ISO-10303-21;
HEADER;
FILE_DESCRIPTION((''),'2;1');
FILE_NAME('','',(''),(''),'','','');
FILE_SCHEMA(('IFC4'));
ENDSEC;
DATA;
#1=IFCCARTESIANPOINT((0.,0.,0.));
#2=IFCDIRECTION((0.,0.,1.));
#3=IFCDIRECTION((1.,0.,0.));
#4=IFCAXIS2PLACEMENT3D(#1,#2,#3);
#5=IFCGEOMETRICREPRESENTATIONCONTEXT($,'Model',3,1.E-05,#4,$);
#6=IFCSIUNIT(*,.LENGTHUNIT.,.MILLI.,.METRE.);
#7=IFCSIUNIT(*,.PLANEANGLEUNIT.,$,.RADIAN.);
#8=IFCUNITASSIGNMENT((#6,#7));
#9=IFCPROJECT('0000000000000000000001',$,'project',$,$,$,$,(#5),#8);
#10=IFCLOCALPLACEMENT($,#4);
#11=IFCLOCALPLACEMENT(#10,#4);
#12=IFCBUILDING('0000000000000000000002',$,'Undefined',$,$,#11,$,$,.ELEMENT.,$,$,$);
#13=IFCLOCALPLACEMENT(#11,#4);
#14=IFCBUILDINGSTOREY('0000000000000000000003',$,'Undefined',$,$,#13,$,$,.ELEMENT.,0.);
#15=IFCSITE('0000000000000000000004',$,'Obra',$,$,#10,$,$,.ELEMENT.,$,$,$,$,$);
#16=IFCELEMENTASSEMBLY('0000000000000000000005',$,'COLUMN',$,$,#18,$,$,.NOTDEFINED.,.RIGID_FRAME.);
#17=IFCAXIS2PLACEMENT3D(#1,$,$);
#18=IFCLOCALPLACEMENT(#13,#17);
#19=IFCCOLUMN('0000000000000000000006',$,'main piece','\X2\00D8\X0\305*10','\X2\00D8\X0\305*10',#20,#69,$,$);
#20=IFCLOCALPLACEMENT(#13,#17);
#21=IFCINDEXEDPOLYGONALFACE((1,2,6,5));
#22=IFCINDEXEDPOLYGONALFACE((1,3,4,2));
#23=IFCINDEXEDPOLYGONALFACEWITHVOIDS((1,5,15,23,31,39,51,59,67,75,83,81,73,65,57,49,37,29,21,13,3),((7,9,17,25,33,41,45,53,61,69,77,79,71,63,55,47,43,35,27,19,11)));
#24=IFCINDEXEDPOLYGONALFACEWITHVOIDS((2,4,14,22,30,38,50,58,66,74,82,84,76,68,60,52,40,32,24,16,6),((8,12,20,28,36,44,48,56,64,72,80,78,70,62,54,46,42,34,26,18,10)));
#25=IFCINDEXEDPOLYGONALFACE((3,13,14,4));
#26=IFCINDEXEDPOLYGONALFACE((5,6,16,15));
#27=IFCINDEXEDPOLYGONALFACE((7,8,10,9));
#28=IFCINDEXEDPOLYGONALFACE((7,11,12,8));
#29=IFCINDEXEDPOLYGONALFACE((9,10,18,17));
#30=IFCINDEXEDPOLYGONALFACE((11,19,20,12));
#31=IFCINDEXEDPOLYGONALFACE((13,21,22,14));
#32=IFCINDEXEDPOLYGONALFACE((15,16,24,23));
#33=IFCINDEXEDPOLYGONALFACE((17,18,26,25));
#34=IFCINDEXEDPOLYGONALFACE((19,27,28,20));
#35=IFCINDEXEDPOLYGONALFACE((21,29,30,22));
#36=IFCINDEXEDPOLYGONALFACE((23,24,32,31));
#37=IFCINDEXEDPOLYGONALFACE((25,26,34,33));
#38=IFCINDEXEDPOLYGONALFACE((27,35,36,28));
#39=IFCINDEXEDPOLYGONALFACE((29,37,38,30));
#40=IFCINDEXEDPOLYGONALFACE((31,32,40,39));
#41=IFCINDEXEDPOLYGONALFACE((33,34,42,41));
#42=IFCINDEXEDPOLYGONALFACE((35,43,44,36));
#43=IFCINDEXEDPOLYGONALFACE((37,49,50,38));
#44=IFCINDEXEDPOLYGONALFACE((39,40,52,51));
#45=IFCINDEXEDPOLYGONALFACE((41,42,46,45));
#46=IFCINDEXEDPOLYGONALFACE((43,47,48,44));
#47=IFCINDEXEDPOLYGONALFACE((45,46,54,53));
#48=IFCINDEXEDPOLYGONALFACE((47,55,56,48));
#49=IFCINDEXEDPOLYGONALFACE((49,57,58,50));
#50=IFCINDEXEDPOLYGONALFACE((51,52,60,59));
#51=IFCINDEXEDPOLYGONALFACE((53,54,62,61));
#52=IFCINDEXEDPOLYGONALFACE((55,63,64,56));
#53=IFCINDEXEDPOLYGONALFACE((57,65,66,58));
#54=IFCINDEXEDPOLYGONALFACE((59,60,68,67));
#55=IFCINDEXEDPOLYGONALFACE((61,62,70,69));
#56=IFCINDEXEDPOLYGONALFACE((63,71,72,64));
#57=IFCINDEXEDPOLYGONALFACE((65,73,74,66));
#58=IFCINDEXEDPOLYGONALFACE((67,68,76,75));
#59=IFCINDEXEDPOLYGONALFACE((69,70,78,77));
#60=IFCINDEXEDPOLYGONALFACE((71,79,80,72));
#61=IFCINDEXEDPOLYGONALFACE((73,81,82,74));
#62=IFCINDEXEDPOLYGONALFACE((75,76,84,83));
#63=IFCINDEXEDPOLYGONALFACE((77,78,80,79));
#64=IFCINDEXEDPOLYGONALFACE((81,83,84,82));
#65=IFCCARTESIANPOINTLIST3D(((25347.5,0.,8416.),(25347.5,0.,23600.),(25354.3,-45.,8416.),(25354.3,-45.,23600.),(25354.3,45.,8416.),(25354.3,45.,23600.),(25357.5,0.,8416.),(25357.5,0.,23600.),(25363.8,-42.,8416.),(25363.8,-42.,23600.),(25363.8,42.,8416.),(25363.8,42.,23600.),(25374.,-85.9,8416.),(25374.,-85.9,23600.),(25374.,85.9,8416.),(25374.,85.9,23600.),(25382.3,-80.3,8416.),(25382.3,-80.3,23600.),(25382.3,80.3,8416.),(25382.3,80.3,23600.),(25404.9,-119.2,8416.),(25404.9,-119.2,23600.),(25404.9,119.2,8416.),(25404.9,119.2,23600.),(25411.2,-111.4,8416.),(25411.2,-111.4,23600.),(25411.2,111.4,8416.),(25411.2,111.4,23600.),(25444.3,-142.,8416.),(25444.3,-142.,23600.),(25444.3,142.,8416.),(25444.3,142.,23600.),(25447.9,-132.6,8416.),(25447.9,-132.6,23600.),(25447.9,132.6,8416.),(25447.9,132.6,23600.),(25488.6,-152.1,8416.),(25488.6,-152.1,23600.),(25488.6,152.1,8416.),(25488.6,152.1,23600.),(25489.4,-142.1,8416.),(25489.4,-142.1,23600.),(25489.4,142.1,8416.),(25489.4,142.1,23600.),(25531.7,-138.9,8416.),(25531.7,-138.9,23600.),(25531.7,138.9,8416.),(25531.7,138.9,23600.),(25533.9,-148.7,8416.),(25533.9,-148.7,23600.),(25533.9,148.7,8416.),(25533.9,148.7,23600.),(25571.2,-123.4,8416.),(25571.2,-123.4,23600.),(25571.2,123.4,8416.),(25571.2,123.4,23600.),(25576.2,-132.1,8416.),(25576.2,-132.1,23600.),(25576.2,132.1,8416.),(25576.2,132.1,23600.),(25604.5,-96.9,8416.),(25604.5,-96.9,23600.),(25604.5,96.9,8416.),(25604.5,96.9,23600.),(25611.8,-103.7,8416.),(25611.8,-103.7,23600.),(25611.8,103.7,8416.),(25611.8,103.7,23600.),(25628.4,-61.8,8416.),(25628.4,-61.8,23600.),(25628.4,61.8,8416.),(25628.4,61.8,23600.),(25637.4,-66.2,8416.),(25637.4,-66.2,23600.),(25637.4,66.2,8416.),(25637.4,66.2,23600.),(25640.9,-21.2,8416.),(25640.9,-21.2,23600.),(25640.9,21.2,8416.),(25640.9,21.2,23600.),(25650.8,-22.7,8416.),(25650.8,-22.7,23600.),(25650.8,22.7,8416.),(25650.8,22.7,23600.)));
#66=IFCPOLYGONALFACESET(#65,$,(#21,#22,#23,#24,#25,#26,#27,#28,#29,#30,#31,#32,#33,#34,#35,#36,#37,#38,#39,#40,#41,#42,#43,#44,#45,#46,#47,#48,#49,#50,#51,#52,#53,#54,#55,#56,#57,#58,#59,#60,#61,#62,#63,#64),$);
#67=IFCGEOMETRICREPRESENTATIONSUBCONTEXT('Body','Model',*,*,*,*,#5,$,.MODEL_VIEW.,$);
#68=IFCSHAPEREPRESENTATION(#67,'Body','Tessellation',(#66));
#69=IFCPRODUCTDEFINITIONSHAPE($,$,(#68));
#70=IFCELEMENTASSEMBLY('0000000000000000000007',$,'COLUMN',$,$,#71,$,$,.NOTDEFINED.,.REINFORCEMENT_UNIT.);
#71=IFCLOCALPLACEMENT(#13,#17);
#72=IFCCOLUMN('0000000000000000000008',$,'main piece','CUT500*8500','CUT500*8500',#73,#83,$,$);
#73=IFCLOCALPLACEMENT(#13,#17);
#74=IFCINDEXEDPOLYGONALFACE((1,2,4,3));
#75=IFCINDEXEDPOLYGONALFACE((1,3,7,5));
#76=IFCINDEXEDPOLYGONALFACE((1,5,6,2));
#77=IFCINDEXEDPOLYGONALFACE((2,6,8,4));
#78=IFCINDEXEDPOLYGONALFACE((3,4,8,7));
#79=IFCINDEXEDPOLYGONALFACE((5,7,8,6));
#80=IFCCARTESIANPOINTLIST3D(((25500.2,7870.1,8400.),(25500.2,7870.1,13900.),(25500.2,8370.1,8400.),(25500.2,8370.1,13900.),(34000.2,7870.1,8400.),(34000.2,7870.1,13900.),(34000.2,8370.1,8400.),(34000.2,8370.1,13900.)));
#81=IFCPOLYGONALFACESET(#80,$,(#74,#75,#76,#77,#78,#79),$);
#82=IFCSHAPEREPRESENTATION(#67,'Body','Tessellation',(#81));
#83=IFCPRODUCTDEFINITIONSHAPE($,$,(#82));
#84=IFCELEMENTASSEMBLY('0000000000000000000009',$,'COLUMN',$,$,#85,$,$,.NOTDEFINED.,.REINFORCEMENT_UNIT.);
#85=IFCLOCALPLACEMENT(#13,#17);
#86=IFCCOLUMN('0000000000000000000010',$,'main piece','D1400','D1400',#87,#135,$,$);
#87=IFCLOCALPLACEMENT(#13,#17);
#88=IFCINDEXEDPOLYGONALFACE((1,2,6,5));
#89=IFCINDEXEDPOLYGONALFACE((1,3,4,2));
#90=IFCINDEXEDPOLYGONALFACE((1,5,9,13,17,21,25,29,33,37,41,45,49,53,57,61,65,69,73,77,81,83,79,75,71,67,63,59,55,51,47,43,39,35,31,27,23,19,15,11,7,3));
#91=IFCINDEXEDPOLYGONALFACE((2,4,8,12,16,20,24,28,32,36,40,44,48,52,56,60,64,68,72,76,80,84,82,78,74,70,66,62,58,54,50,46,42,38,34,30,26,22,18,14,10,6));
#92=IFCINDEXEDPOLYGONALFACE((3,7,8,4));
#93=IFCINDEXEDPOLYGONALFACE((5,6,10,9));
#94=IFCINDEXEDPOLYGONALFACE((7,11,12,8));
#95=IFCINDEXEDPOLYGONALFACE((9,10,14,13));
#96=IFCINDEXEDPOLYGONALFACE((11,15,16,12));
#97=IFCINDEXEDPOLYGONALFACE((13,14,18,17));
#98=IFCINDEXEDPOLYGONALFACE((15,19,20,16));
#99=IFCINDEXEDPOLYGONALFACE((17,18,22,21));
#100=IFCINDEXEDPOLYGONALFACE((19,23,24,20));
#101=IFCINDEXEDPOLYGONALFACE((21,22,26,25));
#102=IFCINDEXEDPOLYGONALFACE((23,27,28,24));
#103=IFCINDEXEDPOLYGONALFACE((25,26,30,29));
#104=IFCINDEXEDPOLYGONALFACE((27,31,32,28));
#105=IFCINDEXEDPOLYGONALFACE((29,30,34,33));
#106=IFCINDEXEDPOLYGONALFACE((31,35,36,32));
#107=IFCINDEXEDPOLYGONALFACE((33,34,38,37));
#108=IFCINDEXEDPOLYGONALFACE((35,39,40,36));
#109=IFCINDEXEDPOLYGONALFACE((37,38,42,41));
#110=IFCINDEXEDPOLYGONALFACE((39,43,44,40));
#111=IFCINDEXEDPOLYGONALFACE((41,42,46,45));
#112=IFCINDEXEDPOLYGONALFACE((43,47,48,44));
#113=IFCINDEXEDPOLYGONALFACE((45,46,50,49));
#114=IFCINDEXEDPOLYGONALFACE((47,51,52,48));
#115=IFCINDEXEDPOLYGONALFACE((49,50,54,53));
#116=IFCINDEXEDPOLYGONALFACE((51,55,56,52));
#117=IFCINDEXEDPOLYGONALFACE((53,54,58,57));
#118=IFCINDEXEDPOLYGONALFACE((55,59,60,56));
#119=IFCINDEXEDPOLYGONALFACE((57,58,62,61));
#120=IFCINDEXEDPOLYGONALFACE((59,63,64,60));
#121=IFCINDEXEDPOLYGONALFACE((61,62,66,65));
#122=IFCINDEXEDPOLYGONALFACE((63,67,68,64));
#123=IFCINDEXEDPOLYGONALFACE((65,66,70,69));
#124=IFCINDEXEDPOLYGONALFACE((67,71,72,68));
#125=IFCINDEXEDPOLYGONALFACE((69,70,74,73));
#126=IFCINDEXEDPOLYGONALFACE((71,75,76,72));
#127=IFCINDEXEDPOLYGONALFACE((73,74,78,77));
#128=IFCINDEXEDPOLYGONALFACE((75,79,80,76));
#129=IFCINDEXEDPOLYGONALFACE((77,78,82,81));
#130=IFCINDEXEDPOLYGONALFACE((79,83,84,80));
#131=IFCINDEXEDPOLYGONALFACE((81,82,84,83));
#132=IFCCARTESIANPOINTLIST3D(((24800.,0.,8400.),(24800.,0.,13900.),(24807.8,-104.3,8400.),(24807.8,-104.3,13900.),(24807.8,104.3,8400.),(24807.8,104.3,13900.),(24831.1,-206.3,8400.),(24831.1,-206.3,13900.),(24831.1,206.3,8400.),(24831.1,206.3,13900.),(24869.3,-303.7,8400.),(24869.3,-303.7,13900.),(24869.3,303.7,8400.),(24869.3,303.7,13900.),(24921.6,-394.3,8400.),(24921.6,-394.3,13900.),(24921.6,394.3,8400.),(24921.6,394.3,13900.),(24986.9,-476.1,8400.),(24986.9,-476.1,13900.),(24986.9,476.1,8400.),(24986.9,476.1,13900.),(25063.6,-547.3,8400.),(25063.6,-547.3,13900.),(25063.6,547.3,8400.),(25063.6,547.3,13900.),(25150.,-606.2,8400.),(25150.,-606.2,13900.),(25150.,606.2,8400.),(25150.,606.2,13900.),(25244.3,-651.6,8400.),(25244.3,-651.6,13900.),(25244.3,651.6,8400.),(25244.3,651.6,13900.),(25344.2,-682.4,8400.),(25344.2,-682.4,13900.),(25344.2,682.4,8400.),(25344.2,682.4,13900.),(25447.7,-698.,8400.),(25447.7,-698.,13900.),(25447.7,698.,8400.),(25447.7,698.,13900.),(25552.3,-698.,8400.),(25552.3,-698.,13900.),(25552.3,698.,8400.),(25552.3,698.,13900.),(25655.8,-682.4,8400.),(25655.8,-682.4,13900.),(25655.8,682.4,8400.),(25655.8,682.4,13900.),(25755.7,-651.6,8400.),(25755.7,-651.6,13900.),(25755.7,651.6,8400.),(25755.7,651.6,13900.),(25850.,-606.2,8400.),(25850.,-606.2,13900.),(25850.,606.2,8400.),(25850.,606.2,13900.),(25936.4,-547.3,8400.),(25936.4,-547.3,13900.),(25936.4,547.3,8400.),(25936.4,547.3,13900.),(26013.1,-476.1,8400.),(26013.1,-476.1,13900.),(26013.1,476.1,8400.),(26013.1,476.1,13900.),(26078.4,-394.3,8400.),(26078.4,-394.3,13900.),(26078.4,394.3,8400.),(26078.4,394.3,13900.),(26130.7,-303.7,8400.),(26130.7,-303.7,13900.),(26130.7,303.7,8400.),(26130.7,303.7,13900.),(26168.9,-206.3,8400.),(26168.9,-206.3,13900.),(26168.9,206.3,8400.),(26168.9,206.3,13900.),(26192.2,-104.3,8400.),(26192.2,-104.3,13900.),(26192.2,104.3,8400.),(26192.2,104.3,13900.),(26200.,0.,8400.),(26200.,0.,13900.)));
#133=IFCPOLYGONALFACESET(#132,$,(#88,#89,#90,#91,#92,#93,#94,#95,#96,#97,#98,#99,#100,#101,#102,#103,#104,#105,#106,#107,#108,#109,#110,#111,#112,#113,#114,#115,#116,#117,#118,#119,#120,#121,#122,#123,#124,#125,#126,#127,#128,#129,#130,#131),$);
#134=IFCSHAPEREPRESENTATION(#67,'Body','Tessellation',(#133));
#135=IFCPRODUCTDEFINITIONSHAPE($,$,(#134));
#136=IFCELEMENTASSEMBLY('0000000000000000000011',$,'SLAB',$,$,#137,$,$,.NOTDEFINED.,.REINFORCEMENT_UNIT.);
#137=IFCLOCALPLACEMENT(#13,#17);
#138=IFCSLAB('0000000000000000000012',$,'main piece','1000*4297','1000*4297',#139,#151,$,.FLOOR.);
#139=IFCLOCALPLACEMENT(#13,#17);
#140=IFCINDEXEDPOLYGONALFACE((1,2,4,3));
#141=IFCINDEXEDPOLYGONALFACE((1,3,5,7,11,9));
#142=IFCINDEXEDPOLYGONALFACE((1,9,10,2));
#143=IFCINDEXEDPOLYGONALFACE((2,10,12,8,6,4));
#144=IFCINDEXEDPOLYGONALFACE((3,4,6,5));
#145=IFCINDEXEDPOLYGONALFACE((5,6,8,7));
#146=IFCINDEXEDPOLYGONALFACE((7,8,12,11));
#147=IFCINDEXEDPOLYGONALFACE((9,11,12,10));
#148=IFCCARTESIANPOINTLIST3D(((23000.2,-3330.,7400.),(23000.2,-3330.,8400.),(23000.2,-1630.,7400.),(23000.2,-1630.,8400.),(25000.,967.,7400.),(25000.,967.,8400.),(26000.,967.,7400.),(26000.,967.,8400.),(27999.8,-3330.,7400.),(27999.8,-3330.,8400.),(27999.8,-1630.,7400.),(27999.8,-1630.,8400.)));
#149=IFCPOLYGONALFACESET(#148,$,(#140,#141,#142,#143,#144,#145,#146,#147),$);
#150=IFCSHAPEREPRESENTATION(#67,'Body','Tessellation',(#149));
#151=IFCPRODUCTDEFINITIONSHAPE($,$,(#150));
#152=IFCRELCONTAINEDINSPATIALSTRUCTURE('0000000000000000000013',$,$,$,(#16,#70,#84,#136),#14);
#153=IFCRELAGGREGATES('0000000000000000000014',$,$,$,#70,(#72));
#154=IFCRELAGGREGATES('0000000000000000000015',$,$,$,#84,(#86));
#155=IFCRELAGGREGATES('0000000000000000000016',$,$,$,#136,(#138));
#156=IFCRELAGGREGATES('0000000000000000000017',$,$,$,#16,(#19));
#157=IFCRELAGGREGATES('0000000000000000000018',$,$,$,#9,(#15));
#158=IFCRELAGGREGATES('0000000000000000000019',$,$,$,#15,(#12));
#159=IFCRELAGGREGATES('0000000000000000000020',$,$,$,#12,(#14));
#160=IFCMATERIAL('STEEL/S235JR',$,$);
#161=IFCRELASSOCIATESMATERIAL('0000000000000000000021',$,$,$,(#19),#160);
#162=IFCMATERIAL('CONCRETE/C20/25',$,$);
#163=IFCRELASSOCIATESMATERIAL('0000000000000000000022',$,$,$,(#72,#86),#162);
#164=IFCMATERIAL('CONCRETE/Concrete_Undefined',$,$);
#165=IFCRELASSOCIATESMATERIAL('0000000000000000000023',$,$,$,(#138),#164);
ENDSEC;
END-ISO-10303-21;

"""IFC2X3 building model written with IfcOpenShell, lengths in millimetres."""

from ifc_helpers import new_model, si_unit, frame, origin_with_axes, origin_2d_with_axis, place, context, subcontext, project, spatial, polyline, rectangle, circle, hollow_circle, outline, extrude, clip, halfspace, material, element, aggregate, save


model = new_model("IFC2X3")

# Units and contexts
model_context = context("Model", 3, precision=1e-05, world=origin_with_axes())
body_context = subcontext(model_context, "Body", "Model", "MODEL_VIEW")
ifc_project = project(units=[si_unit("LENGTHUNIT", "METRE", prefix="MILLI"), si_unit("PLANEANGLEUNIT", "RADIAN")], contexts=[model_context])

# Site, building, storey
site_placement = place(None, origin_with_axes())
site = spatial("IfcSite", under=ifc_project, at=site_placement, Name="Obra", CompositionType="ELEMENT")
building_placement = place(site_placement, origin_with_axes())
building = spatial("IfcBuilding", under=site, at=building_placement, Name="Undefined", CompositionType="ELEMENT")
storey_placement = place(building_placement, origin_with_axes())
storey = spatial("IfcBuildingStorey", under=building, at=storey_placement, Name="Undefined", CompositionType="ELEMENT", Elevation=0.0)

# Element assemblies, columns
assembly_1_placement = place(storey_placement, origin_with_axes())
assembly_1 = element("IfcElementAssembly", 1, at=assembly_1_placement, inside=storey, Name="COLUMN", AssemblyPlace="NOTDEFINED", PredefinedType="RIGID_FRAME")
ifc_material_1 = material(Name="STEEL/S235JR")
column_1_placement = place(assembly_1_placement, frame((25500.0, 0.0, 8400.0), z_axis=(0.0, 0.0, 1.0), x_axis=(0.0, 1.0, 0.0)))
column_1 = element("IfcColumn", 2, at=column_1_placement, material=ifc_material_1, Name="main piece", Description="Ø305*10", ObjectType="Ø305*10", context=body_context, shape_type="Clipping", body=[
    clip(extrude(hollow_circle(Radius=152.5, WallThickness=10.0, at=origin_2d_with_axis()), frame((0.0, 0.0, 15200.0), z_axis=(0.0, 0.0, -1.0), x_axis=(0.0, 1.0, 0.0)), (0.0, 0.0, 1.0), 15184.0), halfspace(frame((-152.5, 0.0, 16.0), z_axis=(0.0, 0.0, 1.0), x_axis=(0.0, 1.0, 0.0)), True)),
])
assembly_2_placement = place(storey_placement, origin_with_axes())
assembly_2 = element("IfcElementAssembly", 3, at=assembly_2_placement, inside=storey, Name="COLUMN", AssemblyPlace="NOTDEFINED", PredefinedType="REINFORCEMENT_UNIT")
ifc_material_2 = material(Name="CONCRETE/C20/25")
column_2_placement = place(assembly_2_placement, frame((29750.2, 8120.1, 8400.0), z_axis=(0.0, 0.0, 1.0), x_axis=(-1.0, 0.0, 0.0)))
column_2 = element("IfcColumn", 4, at=column_2_placement, material=ifc_material_2, Name="main piece", Description="CUT500*8500", ObjectType="CUT500*8500", context=body_context, shape_type="SweptSolid", body=[
    extrude(rectangle(XDim=500.0, YDim=8500.0, at=origin_2d_with_axis()), frame((0.0, 0.0, 5500.0), z_axis=(0.0, 0.0, -1.0), x_axis=(0.0, 1.0, 0.0)), (0.0, 0.0, 1.0), 5500.0),
])
aggregate(assembly_2, [column_2])
assembly_3_placement = place(storey_placement, origin_with_axes())
assembly_3 = element("IfcElementAssembly", 5, at=assembly_3_placement, inside=storey, Name="COLUMN", AssemblyPlace="NOTDEFINED", PredefinedType="REINFORCEMENT_UNIT")
column_3_placement = place(assembly_3_placement, frame((25500.0, 0.0, 8400.0), z_axis=(0.0, 0.0, 1.0), x_axis=(0.0, 1.0, 0.0)))
column_3 = element("IfcColumn", 6, at=column_3_placement, material=ifc_material_2, Name="main piece", Description="D1400", ObjectType="D1400", context=body_context, shape_type="SweptSolid", body=[
    extrude(circle(Radius=700.0, at=origin_2d_with_axis()), frame((0.0, 0.0, 5500.0), z_axis=(0.0, 0.0, -1.0), x_axis=(0.0, 1.0, 0.0)), (0.0, 0.0, 1.0), 5500.0),
])
aggregate(assembly_3, [column_3])

# Element assembly, slab
assembly_4_placement = place(storey_placement, origin_with_axes())
assembly_4 = element("IfcElementAssembly", 7, at=assembly_4_placement, inside=storey, Name="SLAB", AssemblyPlace="NOTDEFINED", PredefinedType="REINFORCEMENT_UNIT")
ifc_material_3 = material(Name="CONCRETE/Concrete_Undefined")
slab_placement = place(assembly_4_placement, frame((23000.2, -1630.0, 7900.0), z_axis=(0.0, 0.0, 1.0), x_axis=(0.0, -1.0, 0.0)))
slab = element("IfcSlab", 8, at=slab_placement, material=ifc_material_3, Name="main piece", Description="1000*4297", ObjectType="1000*4297", PredefinedType="FLOOR", context=body_context, shape_type="SweptSolid", body=[
    extrude(outline(polyline([(0.0, 0.0), (1700.0, 0.0), (1700.0, 4999.6), (0.0, 4999.6), (-2597.0, 2999.8), (-2597.0, 1999.8), (0.0, 0.0)])), frame((0.0, 0.0, -500.0), z_axis=(0.0, 0.0, 1.0), x_axis=(1.0, 0.0, 0.0)), (0.0, 0.0, 1.0), 1000.0),
])
aggregate(assembly_4, [slab])

aggregate(assembly_1, [column_1])

save(model, "model.ifc")
